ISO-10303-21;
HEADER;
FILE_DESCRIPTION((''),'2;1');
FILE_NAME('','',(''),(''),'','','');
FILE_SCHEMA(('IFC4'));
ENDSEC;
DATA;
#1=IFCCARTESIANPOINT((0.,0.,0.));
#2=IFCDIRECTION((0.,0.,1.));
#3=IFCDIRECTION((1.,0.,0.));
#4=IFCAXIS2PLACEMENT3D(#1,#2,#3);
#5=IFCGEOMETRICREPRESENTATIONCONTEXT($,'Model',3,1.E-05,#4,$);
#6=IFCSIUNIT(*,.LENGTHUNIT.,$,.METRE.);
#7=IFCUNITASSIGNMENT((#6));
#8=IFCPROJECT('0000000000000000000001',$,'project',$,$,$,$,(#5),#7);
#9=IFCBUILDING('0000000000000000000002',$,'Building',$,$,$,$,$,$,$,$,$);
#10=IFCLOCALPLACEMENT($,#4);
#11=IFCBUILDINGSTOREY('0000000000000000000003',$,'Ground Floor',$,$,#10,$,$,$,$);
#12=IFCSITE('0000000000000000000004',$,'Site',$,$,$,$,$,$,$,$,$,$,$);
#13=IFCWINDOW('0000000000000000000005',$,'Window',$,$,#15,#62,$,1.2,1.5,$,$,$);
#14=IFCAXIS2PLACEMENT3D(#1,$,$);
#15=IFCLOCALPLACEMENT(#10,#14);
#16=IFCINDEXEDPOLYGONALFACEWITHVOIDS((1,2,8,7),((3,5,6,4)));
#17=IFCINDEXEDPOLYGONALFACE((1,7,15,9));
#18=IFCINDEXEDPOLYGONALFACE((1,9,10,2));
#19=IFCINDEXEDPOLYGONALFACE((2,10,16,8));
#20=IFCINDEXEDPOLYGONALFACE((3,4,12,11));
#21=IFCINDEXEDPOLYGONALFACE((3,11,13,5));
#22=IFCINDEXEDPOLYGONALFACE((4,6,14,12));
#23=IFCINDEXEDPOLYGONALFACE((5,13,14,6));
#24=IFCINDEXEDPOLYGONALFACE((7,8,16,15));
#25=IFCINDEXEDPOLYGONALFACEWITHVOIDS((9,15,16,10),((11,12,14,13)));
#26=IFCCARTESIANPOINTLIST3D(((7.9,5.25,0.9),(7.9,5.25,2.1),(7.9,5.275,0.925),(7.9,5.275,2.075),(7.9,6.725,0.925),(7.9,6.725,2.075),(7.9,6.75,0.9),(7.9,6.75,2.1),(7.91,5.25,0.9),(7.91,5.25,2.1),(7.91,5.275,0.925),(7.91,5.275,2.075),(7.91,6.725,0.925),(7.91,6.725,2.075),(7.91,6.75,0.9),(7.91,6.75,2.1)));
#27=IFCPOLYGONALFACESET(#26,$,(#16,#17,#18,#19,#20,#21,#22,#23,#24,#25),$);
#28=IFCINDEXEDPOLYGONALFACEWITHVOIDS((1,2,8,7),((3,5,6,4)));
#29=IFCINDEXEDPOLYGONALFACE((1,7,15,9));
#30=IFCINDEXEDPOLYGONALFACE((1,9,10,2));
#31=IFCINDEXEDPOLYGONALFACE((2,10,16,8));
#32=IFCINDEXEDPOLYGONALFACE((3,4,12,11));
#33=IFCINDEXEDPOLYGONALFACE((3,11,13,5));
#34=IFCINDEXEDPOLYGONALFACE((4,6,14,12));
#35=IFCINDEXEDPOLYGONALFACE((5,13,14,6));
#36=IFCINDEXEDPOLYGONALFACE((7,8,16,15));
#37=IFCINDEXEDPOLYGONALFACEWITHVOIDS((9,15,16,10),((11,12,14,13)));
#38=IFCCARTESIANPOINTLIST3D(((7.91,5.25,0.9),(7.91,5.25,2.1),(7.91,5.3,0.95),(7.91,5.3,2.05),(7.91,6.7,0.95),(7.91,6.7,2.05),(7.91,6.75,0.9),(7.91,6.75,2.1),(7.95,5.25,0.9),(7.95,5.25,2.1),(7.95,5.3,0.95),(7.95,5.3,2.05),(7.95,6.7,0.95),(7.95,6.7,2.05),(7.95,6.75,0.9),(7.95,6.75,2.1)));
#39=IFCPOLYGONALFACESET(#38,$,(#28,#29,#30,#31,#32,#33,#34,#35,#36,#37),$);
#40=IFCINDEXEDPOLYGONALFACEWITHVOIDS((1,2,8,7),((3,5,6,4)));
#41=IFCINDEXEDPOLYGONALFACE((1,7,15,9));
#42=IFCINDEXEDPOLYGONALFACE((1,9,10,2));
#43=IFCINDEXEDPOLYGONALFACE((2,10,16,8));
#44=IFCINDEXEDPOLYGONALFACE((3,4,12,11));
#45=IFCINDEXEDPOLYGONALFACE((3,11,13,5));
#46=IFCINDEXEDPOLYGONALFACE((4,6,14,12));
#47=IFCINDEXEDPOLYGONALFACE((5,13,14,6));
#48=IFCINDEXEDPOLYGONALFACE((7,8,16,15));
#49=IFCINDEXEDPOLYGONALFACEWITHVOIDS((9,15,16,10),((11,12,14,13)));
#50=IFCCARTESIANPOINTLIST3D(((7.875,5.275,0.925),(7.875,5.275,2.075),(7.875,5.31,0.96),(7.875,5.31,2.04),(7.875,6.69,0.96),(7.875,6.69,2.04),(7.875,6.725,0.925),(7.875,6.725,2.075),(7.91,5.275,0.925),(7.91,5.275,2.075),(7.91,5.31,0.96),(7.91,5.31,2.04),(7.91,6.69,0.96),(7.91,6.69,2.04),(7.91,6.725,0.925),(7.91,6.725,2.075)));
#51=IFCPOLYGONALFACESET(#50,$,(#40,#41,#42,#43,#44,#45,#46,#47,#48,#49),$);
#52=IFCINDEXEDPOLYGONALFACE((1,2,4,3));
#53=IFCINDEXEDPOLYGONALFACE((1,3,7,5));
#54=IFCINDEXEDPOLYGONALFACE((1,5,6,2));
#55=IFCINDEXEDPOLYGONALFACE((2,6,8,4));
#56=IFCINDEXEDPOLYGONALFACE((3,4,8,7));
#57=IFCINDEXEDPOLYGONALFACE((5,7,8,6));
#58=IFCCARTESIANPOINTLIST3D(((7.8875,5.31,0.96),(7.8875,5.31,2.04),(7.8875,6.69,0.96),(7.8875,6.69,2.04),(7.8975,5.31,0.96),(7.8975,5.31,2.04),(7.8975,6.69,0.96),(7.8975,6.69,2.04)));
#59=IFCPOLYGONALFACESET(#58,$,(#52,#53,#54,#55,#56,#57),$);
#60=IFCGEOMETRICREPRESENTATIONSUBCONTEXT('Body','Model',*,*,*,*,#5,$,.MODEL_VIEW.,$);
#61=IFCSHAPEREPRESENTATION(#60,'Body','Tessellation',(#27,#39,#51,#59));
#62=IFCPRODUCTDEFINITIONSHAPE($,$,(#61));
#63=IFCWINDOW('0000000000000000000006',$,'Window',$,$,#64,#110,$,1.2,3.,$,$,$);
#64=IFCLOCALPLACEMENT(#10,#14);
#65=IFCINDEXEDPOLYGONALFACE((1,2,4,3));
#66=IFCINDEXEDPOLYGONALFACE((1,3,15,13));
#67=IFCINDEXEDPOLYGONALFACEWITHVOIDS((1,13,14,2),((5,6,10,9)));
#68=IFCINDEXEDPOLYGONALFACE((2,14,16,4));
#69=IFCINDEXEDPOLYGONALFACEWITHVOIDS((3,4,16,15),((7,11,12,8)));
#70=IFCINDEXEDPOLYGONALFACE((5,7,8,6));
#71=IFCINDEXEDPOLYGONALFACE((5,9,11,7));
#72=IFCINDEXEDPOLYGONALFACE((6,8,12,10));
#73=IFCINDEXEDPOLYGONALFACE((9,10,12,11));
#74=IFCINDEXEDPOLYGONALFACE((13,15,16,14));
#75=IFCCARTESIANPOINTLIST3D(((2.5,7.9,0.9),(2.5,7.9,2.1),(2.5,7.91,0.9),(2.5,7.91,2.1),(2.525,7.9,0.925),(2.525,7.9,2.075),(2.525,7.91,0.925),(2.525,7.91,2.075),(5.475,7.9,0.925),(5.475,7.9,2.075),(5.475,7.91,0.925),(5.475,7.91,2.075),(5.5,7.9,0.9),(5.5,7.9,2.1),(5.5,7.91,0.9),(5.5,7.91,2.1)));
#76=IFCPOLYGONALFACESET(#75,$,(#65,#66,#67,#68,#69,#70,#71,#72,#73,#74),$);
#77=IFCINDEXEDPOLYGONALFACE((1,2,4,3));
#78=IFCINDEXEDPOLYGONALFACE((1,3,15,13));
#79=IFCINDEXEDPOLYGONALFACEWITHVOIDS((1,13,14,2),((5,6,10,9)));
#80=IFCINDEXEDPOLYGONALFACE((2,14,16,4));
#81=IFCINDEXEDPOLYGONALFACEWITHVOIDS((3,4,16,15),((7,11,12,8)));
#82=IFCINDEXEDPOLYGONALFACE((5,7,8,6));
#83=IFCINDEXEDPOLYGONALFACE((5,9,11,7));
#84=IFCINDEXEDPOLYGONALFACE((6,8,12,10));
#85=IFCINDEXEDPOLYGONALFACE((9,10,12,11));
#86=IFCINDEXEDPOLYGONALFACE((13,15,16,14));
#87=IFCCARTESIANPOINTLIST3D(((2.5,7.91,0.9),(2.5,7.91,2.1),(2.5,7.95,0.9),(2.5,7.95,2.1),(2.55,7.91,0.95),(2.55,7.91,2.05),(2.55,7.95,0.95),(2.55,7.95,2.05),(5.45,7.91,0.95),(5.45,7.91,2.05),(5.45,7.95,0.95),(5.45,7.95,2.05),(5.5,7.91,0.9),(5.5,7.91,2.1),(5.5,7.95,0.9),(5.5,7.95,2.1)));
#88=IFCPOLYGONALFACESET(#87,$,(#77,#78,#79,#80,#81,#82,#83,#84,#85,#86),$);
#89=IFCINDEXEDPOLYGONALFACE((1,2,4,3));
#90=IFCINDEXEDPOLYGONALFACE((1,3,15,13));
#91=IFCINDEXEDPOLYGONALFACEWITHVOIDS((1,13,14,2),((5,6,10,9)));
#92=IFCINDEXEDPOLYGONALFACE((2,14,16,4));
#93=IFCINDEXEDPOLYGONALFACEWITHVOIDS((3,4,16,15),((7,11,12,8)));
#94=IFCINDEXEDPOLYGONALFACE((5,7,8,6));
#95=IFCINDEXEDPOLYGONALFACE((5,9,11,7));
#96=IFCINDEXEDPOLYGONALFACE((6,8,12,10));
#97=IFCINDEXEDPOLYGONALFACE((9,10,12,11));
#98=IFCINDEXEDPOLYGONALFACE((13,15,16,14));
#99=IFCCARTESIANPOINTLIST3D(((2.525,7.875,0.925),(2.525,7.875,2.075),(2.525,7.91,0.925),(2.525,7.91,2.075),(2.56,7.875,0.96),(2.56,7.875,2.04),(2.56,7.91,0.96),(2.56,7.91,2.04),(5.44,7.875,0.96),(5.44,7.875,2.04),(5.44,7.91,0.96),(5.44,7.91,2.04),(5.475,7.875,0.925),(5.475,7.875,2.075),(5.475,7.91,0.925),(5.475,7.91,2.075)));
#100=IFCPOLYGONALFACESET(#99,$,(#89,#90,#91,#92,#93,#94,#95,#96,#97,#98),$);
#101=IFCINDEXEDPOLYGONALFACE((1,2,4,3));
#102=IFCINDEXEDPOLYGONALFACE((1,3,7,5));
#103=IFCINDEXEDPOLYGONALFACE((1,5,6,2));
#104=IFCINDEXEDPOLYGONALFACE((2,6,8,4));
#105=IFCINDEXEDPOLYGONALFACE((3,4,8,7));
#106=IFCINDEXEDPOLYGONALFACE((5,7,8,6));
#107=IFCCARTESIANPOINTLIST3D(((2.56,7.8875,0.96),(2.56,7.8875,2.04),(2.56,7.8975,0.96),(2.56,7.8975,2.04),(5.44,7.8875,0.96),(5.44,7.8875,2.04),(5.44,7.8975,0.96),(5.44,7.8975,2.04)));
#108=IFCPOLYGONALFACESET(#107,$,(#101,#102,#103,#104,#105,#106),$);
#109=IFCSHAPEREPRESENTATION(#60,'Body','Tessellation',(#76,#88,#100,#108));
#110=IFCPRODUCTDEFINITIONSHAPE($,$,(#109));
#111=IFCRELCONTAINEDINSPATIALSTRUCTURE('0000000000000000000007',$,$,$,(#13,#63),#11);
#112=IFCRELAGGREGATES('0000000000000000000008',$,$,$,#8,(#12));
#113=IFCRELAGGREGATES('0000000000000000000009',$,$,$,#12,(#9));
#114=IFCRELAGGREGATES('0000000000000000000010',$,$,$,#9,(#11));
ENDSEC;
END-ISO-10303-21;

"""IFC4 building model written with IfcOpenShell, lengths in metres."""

from ifc_helpers import new_model, si_unit, frame, origin_with_axes, place, context, subcontext, project, spatial, line, indexed_curve, outline, extrude, element, save


model = new_model("IFC4")

# Units and contexts
model_context = context("Model", 3, precision=1e-05, world=origin_with_axes())
body_context = subcontext(model_context, "Body", "Model", "MODEL_VIEW")
ifc_project = project(units=[si_unit("LENGTHUNIT", "METRE")], contexts=[model_context])

# Site, building, storey
site = spatial("IfcSite", under=ifc_project, Name="Site")
building = spatial("IfcBuilding", under=site, Name="Building")
storey_placement = place(None, origin_with_axes())
storey = spatial("IfcBuildingStorey", under=building, at=storey_placement, Name="Ground Floor")

# Windows
window_1_placement = place(storey_placement, frame((8.0, 5.25, 0.9), z_axis=(0.0, 0.0, 1.0), x_axis=(0.0, 1.0, 0.0)))
element("IfcWindow", 1, at=window_1_placement, inside=storey, Name="Window", OverallHeight=1.2, OverallWidth=1.5, context=body_context, shape_type="SweptSolid", body=[
    extrude(outline(indexed_curve([(0.0, 0.0), (1.5, 0.0), (1.5, 1.2), (0.0, 1.2)], segments=[line(1, 2, 3, 4, 1)]), holes=[indexed_curve([(0.025, 0.025), (1.475, 0.025), (1.475, 1.175), (0.025, 1.175)], segments=[line(1, 2, 3, 4, 1)])]), frame((0.0, 0.09, 0.0), z_axis=(0.0, -1.0, 0.0), x_axis=(1.0, 0.0, 0.0)), (0.0, 0.0, -1.0), 0.01),
    extrude(outline(indexed_curve([(0.0, 0.0), (1.5, 0.0), (1.5, 1.2), (0.0, 1.2)], segments=[line(1, 2, 3, 4, 1)]), holes=[indexed_curve([(0.05, 0.05), (1.45, 0.05), (1.45, 1.15), (0.05, 1.15)], segments=[line(1, 2, 3, 4, 1)])]), frame((0.0, 0.05, 0.0), z_axis=(0.0, -1.0, 0.0), x_axis=(1.0, 0.0, 0.0)), (0.0, 0.0, -1.0), 0.04),
    extrude(outline(indexed_curve([(0.0, 0.0), (1.45, 0.0), (1.45, 1.15), (0.0, 1.15)], segments=[line(1, 2, 3, 4, 1)]), holes=[indexed_curve([(0.035, 0.035), (1.415, 0.035), (1.415, 1.115), (0.035, 1.115)], segments=[line(1, 2, 3, 4, 1)])]), frame((0.025, 0.09, 0.025), z_axis=(0.0, -1.0, 0.0), x_axis=(1.0, 0.0, 0.0)), (0.0, 0.0, -1.0), 0.035),
    extrude(outline(indexed_curve([(0.035, 0.035), (1.415, 0.035), (1.415, 1.115), (0.035, 1.115)], segments=[line(1, 2, 3, 4, 1)])), frame((0.025, 0.1025, 0.025), z_axis=(0.0, -1.0, 0.0), x_axis=(1.0, 0.0, 0.0)), (0.0, 0.0, -1.0), 0.01),
])
window_2_placement = place(storey_placement, frame((5.5, 8.0, 0.9), z_axis=(0.0, 0.0, 1.0), x_axis=(-1.0, 0.0, 0.0)))
element("IfcWindow", 2, at=window_2_placement, inside=storey, Name="Window", OverallHeight=1.2, OverallWidth=3.0, context=body_context, shape_type="SweptSolid", body=[
    extrude(outline(indexed_curve([(0.0, 0.0), (3.0, 0.0), (3.0, 1.2), (0.0, 1.2)], segments=[line(1, 2, 3, 4, 1)]), holes=[indexed_curve([(0.025, 0.025), (2.975, 0.025), (2.975, 1.175), (0.025, 1.175)], segments=[line(1, 2, 3, 4, 1)])]), frame((0.0, 0.09, 0.0), z_axis=(0.0, -1.0, 0.0), x_axis=(1.0, 0.0, 0.0)), (0.0, 0.0, -1.0), 0.01),
    extrude(outline(indexed_curve([(0.0, 0.0), (3.0, 0.0), (3.0, 1.2), (0.0, 1.2)], segments=[line(1, 2, 3, 4, 1)]), holes=[indexed_curve([(0.05, 0.05), (2.95, 0.05), (2.95, 1.15), (0.05, 1.15)], segments=[line(1, 2, 3, 4, 1)])]), frame((0.0, 0.05, 0.0), z_axis=(0.0, -1.0, 0.0), x_axis=(1.0, 0.0, 0.0)), (0.0, 0.0, -1.0), 0.04),
    extrude(outline(indexed_curve([(0.0, 0.0), (2.95, 0.0), (2.95, 1.15), (0.0, 1.15)], segments=[line(1, 2, 3, 4, 1)]), holes=[indexed_curve([(0.035, 0.035), (2.915, 0.035), (2.915, 1.115), (0.035, 1.115)], segments=[line(1, 2, 3, 4, 1)])]), frame((0.025, 0.09, 0.025), z_axis=(0.0, -1.0, 0.0), x_axis=(1.0, 0.0, 0.0)), (0.0, 0.0, -1.0), 0.035),
    extrude(outline(indexed_curve([(0.035, 0.035), (2.915, 0.035), (2.915, 1.115), (0.035, 1.115)], segments=[line(1, 2, 3, 4, 1)])), frame((0.025, 0.1025, 0.025), z_axis=(0.0, -1.0, 0.0), x_axis=(1.0, 0.0, 0.0)), (0.0, 0.0, -1.0), 0.01),
])

save(model, "model.ifc")
